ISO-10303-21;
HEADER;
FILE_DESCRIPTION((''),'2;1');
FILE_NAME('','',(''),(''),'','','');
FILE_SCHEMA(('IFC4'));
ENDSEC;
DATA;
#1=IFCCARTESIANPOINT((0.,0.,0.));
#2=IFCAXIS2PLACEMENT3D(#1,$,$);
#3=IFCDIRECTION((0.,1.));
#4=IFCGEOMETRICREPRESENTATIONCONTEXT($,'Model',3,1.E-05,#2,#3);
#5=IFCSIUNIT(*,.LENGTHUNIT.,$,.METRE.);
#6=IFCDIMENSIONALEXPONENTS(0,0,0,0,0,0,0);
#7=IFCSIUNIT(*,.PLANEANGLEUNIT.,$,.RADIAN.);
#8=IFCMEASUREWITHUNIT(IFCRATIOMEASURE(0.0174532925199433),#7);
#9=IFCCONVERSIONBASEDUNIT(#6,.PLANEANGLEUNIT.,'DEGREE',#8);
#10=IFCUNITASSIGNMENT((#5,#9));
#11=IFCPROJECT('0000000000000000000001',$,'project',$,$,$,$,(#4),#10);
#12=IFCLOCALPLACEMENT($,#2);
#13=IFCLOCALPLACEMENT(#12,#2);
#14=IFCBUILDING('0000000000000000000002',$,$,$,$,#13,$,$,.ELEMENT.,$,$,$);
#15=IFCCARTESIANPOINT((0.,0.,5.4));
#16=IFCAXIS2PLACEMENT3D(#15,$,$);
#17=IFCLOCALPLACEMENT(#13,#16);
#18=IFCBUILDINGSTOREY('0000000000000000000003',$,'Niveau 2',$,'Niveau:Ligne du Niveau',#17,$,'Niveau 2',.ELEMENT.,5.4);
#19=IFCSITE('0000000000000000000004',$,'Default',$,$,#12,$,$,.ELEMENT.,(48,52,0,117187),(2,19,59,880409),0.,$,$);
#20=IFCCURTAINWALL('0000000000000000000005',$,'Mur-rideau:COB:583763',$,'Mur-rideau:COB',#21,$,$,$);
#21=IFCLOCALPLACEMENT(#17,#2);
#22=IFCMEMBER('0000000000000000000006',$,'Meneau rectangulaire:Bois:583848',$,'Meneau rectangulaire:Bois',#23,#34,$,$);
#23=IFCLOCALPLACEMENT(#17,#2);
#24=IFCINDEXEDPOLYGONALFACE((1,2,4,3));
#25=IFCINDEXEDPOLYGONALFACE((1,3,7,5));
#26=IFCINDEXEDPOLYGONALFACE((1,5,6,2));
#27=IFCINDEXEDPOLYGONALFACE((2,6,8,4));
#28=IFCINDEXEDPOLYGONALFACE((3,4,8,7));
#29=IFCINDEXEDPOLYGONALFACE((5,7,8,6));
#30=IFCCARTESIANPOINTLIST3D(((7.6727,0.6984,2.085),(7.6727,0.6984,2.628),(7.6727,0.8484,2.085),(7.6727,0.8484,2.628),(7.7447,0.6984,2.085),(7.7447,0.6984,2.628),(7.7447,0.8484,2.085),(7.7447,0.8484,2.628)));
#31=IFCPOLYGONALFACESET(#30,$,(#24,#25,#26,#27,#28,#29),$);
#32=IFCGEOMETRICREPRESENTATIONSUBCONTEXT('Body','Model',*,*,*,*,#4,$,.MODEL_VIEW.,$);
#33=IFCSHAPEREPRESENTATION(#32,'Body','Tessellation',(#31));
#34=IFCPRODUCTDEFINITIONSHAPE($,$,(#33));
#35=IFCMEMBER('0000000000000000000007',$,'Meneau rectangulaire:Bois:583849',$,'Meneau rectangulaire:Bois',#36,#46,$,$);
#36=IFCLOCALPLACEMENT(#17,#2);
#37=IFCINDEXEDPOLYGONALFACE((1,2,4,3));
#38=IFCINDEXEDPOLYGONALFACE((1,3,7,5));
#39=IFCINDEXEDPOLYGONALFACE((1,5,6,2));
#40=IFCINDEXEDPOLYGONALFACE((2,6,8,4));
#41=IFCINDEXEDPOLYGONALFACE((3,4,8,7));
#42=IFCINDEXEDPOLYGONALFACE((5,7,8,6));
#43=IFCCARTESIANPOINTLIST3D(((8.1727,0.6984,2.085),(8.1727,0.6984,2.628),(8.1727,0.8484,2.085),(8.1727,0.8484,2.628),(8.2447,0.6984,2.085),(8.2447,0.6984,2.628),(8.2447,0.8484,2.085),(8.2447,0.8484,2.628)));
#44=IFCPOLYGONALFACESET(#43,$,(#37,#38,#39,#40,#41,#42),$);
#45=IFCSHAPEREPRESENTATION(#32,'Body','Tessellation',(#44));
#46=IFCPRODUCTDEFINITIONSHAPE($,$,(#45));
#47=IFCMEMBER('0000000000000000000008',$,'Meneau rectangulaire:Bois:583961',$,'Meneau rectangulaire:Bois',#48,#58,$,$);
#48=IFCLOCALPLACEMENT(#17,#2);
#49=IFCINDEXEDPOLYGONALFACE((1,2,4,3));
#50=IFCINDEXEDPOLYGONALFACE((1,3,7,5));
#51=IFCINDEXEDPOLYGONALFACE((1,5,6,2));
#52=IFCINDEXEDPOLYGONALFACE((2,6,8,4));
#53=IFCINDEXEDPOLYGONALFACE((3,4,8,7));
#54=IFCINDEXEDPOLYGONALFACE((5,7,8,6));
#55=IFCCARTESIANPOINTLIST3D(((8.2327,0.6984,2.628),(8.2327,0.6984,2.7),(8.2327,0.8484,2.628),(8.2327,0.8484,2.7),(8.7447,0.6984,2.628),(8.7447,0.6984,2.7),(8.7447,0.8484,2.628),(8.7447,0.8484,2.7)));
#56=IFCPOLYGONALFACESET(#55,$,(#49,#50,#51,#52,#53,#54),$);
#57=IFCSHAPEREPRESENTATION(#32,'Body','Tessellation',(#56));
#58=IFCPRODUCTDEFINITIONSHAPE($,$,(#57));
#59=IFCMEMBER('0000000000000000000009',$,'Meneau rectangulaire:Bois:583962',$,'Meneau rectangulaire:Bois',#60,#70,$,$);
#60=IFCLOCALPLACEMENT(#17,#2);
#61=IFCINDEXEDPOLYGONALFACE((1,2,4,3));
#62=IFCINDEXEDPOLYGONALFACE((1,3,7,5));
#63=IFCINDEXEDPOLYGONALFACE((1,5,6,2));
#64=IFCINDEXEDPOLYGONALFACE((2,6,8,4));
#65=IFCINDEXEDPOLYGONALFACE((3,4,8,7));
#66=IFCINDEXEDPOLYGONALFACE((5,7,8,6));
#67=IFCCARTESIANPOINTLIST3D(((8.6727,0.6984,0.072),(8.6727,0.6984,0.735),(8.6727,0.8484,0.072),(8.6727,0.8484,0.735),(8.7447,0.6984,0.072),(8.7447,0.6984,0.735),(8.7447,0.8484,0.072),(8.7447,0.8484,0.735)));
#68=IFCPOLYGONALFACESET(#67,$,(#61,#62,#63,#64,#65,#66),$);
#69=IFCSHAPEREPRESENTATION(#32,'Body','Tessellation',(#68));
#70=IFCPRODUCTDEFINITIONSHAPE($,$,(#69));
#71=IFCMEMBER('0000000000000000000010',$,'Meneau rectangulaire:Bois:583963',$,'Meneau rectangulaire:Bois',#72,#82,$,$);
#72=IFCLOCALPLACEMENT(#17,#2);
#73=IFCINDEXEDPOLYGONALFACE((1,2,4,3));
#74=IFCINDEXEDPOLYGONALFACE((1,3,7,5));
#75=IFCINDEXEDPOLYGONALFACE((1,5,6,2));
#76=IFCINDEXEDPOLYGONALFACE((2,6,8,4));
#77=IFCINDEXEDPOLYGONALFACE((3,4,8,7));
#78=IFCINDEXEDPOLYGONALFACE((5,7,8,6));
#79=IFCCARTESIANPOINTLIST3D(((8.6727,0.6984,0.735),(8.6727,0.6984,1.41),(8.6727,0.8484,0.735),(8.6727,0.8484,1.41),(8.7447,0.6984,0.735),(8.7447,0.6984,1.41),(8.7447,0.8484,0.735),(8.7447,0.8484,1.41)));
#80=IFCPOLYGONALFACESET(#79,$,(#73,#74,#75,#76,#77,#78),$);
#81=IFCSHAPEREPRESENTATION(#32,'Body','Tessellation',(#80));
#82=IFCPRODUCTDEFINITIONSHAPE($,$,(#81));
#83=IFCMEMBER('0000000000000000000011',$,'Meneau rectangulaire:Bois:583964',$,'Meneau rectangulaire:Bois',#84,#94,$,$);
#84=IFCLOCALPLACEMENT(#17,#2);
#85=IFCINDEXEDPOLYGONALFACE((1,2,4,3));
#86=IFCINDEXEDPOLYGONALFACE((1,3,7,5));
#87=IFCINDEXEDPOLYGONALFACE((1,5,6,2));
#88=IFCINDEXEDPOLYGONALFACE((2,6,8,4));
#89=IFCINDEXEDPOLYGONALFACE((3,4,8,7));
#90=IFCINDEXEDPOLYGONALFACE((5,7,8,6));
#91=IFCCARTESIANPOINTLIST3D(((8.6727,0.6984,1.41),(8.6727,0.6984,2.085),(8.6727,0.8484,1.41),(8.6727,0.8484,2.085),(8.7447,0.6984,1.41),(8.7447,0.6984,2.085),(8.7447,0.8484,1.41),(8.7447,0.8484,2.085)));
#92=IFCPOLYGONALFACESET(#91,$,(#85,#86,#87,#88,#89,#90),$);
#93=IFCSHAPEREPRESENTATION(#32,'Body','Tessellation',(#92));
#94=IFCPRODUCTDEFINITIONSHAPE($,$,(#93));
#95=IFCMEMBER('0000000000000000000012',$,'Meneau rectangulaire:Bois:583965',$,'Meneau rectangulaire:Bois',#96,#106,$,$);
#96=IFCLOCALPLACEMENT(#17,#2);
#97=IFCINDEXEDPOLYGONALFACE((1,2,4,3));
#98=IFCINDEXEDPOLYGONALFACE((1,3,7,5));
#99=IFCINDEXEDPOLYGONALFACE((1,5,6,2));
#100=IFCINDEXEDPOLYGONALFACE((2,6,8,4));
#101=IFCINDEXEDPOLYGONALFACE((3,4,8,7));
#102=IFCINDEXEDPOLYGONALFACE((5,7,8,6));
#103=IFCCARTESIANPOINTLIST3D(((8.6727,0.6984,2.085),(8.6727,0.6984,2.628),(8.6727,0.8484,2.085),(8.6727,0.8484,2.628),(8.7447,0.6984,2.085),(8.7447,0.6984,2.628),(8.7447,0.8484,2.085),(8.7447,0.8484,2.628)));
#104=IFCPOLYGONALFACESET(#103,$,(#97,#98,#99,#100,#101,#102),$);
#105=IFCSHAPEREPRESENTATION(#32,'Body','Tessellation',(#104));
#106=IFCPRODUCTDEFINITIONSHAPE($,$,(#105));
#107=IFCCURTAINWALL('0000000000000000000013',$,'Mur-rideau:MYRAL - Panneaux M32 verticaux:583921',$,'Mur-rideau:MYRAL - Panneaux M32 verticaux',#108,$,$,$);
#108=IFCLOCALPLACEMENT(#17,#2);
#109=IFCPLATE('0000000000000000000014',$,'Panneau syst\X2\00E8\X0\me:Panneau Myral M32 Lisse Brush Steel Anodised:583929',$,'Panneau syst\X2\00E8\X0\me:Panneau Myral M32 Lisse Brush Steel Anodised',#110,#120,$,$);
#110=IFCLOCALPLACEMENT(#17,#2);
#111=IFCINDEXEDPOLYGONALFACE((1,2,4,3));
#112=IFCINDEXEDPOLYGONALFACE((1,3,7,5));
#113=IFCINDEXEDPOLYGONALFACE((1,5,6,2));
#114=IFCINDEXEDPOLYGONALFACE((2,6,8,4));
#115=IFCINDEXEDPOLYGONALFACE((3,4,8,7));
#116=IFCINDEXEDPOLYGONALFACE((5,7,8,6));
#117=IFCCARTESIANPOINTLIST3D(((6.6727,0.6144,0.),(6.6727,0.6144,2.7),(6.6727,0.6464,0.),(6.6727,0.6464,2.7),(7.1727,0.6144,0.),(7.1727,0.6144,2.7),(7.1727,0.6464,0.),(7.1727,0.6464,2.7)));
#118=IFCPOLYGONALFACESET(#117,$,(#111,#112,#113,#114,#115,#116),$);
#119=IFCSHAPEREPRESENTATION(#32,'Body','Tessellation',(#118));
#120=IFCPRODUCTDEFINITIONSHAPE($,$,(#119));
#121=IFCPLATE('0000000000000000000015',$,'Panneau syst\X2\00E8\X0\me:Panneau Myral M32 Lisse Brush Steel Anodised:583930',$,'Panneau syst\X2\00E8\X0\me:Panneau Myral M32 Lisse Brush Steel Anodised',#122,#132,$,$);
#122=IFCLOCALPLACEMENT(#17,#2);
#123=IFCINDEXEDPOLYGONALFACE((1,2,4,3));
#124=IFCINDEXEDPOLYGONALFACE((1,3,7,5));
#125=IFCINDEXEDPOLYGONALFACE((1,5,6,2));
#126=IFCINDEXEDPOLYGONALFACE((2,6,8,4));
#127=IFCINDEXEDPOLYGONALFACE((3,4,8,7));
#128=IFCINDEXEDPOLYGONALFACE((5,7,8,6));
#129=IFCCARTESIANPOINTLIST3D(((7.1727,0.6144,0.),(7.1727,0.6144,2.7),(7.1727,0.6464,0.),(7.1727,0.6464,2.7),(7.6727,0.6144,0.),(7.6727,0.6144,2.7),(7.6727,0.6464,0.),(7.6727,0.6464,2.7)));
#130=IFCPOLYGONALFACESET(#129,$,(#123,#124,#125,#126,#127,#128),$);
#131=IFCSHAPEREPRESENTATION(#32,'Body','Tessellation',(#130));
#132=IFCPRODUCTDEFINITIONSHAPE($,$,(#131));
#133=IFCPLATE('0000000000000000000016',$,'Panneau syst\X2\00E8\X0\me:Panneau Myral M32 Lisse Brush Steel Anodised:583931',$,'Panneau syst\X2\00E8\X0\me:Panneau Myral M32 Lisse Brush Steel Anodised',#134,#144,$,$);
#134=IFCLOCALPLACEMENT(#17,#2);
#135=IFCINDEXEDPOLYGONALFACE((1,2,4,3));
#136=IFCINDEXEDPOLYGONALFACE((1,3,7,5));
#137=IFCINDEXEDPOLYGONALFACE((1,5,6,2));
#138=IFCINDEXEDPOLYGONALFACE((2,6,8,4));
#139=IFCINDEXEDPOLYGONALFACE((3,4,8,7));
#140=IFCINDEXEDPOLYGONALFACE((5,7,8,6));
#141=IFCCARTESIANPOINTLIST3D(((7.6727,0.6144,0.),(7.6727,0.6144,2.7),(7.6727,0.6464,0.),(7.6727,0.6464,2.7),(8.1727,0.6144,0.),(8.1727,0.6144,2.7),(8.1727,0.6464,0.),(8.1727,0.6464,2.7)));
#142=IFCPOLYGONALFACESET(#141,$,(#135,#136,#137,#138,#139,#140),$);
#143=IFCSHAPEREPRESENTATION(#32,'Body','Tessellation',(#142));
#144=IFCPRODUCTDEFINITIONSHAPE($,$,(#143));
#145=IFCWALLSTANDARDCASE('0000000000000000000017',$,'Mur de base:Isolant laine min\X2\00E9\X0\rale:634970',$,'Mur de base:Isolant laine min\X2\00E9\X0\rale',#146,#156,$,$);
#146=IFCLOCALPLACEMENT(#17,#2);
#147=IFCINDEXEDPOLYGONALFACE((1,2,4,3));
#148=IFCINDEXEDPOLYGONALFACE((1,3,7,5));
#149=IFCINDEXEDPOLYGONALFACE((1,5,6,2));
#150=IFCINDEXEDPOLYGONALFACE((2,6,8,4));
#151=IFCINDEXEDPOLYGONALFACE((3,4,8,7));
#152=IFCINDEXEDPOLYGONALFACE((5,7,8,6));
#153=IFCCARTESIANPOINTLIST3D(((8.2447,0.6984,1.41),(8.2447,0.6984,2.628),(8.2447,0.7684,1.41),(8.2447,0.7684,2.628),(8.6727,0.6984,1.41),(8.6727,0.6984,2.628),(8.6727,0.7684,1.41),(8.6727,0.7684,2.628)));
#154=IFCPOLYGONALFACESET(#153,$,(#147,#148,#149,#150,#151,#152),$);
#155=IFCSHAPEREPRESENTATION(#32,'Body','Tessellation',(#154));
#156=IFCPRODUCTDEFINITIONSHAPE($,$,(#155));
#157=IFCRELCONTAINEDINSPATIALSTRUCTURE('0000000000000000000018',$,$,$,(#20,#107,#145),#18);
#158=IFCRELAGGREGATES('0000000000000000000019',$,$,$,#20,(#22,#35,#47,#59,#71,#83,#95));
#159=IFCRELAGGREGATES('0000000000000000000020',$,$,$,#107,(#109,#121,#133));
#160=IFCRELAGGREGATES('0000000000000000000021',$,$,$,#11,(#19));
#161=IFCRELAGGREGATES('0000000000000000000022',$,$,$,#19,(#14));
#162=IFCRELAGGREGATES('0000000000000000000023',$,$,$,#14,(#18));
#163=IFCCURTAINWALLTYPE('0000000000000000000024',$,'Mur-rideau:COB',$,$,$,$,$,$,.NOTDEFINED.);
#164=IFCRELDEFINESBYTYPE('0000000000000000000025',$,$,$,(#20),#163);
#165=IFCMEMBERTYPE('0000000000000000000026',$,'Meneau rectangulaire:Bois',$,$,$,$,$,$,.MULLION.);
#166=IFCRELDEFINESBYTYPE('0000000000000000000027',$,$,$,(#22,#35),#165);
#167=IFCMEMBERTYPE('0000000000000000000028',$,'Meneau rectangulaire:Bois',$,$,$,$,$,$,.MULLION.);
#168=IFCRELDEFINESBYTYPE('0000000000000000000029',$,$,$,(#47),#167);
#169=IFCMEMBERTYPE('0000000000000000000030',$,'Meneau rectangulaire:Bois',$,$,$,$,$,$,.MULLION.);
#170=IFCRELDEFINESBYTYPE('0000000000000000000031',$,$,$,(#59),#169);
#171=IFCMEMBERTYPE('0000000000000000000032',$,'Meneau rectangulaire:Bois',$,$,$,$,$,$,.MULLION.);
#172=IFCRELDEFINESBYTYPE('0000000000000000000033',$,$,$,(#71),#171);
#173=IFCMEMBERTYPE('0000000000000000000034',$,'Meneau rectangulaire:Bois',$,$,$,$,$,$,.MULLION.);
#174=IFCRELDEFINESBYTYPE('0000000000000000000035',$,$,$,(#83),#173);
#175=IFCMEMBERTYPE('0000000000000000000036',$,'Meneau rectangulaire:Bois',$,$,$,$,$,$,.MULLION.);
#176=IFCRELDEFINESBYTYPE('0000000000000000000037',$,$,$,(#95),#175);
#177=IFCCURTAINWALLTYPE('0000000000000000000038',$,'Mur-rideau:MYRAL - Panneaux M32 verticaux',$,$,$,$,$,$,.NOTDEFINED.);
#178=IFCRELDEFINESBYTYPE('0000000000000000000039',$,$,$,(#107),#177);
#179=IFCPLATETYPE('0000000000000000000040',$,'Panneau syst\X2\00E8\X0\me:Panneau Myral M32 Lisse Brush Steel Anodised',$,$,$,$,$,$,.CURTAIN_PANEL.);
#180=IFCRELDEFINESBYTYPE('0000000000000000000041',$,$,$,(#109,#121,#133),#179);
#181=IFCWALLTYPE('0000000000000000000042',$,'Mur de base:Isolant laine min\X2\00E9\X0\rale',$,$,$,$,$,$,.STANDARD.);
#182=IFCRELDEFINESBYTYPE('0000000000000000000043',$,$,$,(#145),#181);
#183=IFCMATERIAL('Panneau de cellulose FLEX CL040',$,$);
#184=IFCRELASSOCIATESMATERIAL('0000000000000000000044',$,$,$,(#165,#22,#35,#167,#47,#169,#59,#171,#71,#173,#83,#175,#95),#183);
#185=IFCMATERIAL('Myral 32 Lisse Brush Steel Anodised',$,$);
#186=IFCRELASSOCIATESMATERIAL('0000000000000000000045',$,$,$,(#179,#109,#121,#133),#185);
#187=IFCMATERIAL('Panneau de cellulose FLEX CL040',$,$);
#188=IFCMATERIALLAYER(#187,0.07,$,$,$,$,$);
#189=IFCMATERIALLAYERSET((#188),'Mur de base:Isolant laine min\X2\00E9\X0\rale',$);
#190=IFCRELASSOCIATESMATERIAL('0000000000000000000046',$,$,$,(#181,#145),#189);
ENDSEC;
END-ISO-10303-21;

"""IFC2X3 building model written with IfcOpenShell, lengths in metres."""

from ifc_helpers import new_model, entity, si_unit, converted_unit, direction, frame, frame_2d, origin, origin_2d_with_axis, place, context, subcontext, project, spatial, rectangle, extrude, source, transform, mapped, material, layer, layer_set, layer_usage, type_object, type_shapes, element, aggregate, save


model = new_model("IFC2X3")

# Units and contexts
model_context = context("Model", 3, precision=1e-05, world=origin(), true_north=direction((0.0, 1.0)))
body_context = subcontext(model_context, "Body", "Model", "MODEL_VIEW")
ifc_project = project(units=[si_unit("LENGTHUNIT", "METRE"), converted_unit("PLANEANGLEUNIT", "DEGREE", entity("IfcRatioMeasure", 0.0174532925199433), si_unit("PLANEANGLEUNIT", "RADIAN"), dimensions=[0, 0, 0, 0, 0, 0, 0])], contexts=[model_context])

# Site, building, storey
site_placement = place(None, origin())
site = spatial("IfcSite", under=ifc_project, at=site_placement, Name="Default", CompositionType="ELEMENT", RefLatitude=(48, 52, 0, 117187), RefLongitude=(2, 19, 59, 880409), RefElevation=0.0)
building_placement = place(site_placement, origin())
building = spatial("IfcBuilding", under=site, at=building_placement, CompositionType="ELEMENT")
storey_placement = place(building_placement, frame((0.0, 0.0, 5.4)))
storey = spatial("IfcBuildingStorey", under=building, at=storey_placement, Name="Niveau 2", ObjectType="Niveau:Ligne du Niveau", LongName="Niveau 2", CompositionType="ELEMENT", Elevation=5.4)

# Curtain wall, members
curtain_wall_type_1 = type_object("IfcCurtainWallType", Name="Mur-rideau:COB", PredefinedType="NOTDEFINED")
curtain_wall_1_placement = place(storey_placement, frame((0.0, 0.0, -5.4)))
curtain_wall_1 = element("IfcCurtainWall", 1, at=curtain_wall_1_placement, inside=storey, type_object=curtain_wall_type_1, Name="Mur-rideau:COB:583763", ObjectType="Mur-rideau:COB")
ifc_material_1 = material(Name="Panneau de cellulose FLEX CL040")
member_type_1 = type_object("IfcMemberType", Name="Meneau rectangulaire:Bois", PredefinedType="MULLION", material=ifc_material_1)
shared_shape_1 = source(origin(), body_context, "Body", "SweptSolid", [
    extrude(rectangle(XDim=0.15, YDim=0.072, at=origin_2d_with_axis()), frame((-0.024, 0.0, -0.543), z_axis=(0.0, 0.0, 1.0), x_axis=(0.0, -1.0, 0.0)), (0.0, 0.0, 1.0), 0.543),
])
type_shapes(member_type_1, [shared_shape_1])
member_1_placement = place(storey_placement, frame((7.7327, 0.7734, 2.085), z_axis=(0.0, 0.0, -1.0), x_axis=(1.0, 0.0, 0.0)))
member_1 = element("IfcMember", 2, at=member_1_placement, type_object=member_type_1, material=ifc_material_1, Name="Meneau rectangulaire:Bois:583848", ObjectType="Meneau rectangulaire:Bois", context=body_context, shape_type="MappedRepresentation", body=[
    mapped(shared_shape_1, transform((0.0, 0.0, 0.0), scale=1.0)),
])
member_2_placement = place(storey_placement, frame((8.2327, 0.7734, 2.085), z_axis=(0.0, 0.0, -1.0), x_axis=(1.0, 0.0, 0.0)))
member_2 = element("IfcMember", 3, at=member_2_placement, type_object=member_type_1, material=ifc_material_1, Name="Meneau rectangulaire:Bois:583849", ObjectType="Meneau rectangulaire:Bois", context=body_context, shape_type="MappedRepresentation", body=[
    mapped(shared_shape_1, transform((0.0, 0.0, 0.0), scale=1.0)),
])
member_type_2 = type_object("IfcMemberType", Name="Meneau rectangulaire:Bois", PredefinedType="MULLION", material=ifc_material_1)
shared_shape_2 = source(origin(), body_context, "Body", "SweptSolid", [
    extrude(rectangle(XDim=0.15, YDim=0.072, at=origin_2d_with_axis()), frame((-0.036, 0.0, -0.512), z_axis=(0.0, 0.0, 1.0), x_axis=(0.0, -1.0, 0.0)), (0.0, 0.0, 1.0), 0.512),
])
type_shapes(member_type_2, [shared_shape_2])
member_3_placement = place(storey_placement, frame((8.7447, 0.7734, 2.7), z_axis=(1.0, 0.0, 0.0), x_axis=(0.0, 0.0, 1.0)))
member_3 = element("IfcMember", 4, at=member_3_placement, type_object=member_type_2, material=ifc_material_1, Name="Meneau rectangulaire:Bois:583961", ObjectType="Meneau rectangulaire:Bois", context=body_context, shape_type="MappedRepresentation", body=[
    mapped(shared_shape_2, transform((0.0, 0.0, 0.0), scale=1.0)),
])
member_type_3 = type_object("IfcMemberType", Name="Meneau rectangulaire:Bois", PredefinedType="MULLION", material=ifc_material_1)
shared_shape_3 = source(origin(), body_context, "Body", "SweptSolid", [
    extrude(rectangle(XDim=0.15, YDim=0.072, at=origin_2d_with_axis()), frame((-0.024, 0.0, -0.663), z_axis=(0.0, 0.0, 1.0), x_axis=(0.0, -1.0, 0.0)), (0.0, 0.0, 1.0), 0.663),
])
type_shapes(member_type_3, [shared_shape_3])
member_4_placement = place(storey_placement, frame((8.7327, 0.7734, 0.072), z_axis=(0.0, 0.0, -1.0), x_axis=(1.0, 0.0, 0.0)))
member_4 = element("IfcMember", 5, at=member_4_placement, type_object=member_type_3, material=ifc_material_1, Name="Meneau rectangulaire:Bois:583962", ObjectType="Meneau rectangulaire:Bois", context=body_context, shape_type="MappedRepresentation", body=[
    mapped(shared_shape_3, transform((0.0, 0.0, 0.0), scale=1.0)),
])
member_type_4 = type_object("IfcMemberType", Name="Meneau rectangulaire:Bois", PredefinedType="MULLION", material=ifc_material_1)
shared_shape_4 = source(origin(), body_context, "Body", "SweptSolid", [
    extrude(rectangle(XDim=0.15, YDim=0.072, at=origin_2d_with_axis()), frame((-0.024, 0.0, -0.675), z_axis=(0.0, 0.0, 1.0), x_axis=(0.0, -1.0, 0.0)), (0.0, 0.0, 1.0), 0.675),
])
type_shapes(member_type_4, [shared_shape_4])
member_5_placement = place(storey_placement, frame((8.7327, 0.7734, 0.735), z_axis=(0.0, 0.0, -1.0), x_axis=(1.0, 0.0, 0.0)))
member_5 = element("IfcMember", 6, at=member_5_placement, type_object=member_type_4, material=ifc_material_1, Name="Meneau rectangulaire:Bois:583963", ObjectType="Meneau rectangulaire:Bois", context=body_context, shape_type="MappedRepresentation", body=[
    mapped(shared_shape_4, transform((0.0, 0.0, 0.0), scale=1.0)),
])
member_type_5 = type_object("IfcMemberType", Name="Meneau rectangulaire:Bois", PredefinedType="MULLION", material=ifc_material_1)
shared_shape_5 = source(origin(), body_context, "Body", "SweptSolid", [
    extrude(rectangle(XDim=0.15, YDim=0.072, at=origin_2d_with_axis()), frame((-0.024, 0.0, -0.675), z_axis=(0.0, 0.0, 1.0), x_axis=(0.0, -1.0, 0.0)), (0.0, 0.0, 1.0), 0.675),
])
type_shapes(member_type_5, [shared_shape_5])
member_6_placement = place(storey_placement, frame((8.7327, 0.7734, 1.41), z_axis=(0.0, 0.0, -1.0), x_axis=(1.0, 0.0, 0.0)))
member_6 = element("IfcMember", 7, at=member_6_placement, type_object=member_type_5, material=ifc_material_1, Name="Meneau rectangulaire:Bois:583964", ObjectType="Meneau rectangulaire:Bois", context=body_context, shape_type="MappedRepresentation", body=[
    mapped(shared_shape_5, transform((0.0, 0.0, 0.0), scale=1.0)),
])
member_type_6 = type_object("IfcMemberType", Name="Meneau rectangulaire:Bois", PredefinedType="MULLION", material=ifc_material_1)
shared_shape_6 = source(origin(), body_context, "Body", "SweptSolid", [
    extrude(rectangle(XDim=0.15, YDim=0.072, at=origin_2d_with_axis()), frame((-0.024, 0.0, -0.543), z_axis=(0.0, 0.0, 1.0), x_axis=(0.0, -1.0, 0.0)), (0.0, 0.0, 1.0), 0.543),
])
type_shapes(member_type_6, [shared_shape_6])
member_7_placement = place(storey_placement, frame((8.7327, 0.7734, 2.085), z_axis=(0.0, 0.0, -1.0), x_axis=(1.0, 0.0, 0.0)))
member_7 = element("IfcMember", 8, at=member_7_placement, type_object=member_type_6, material=ifc_material_1, Name="Meneau rectangulaire:Bois:583965", ObjectType="Meneau rectangulaire:Bois", context=body_context, shape_type="MappedRepresentation", body=[
    mapped(shared_shape_6, transform((0.0, 0.0, 0.0), scale=1.0)),
])
aggregate(curtain_wall_1, [member_1, member_2, member_3, member_4, member_5, member_6, member_7])

# Curtain wall, plates
curtain_wall_type_2 = type_object("IfcCurtainWallType", Name="Mur-rideau:MYRAL - Panneaux M32 verticaux", PredefinedType="NOTDEFINED")
curtain_wall_2_placement = place(storey_placement, frame((0.0, 0.0, -5.4)))
curtain_wall_2 = element("IfcCurtainWall", 9, at=curtain_wall_2_placement, inside=storey, type_object=curtain_wall_type_2, Name="Mur-rideau:MYRAL - Panneaux M32 verticaux:583921", ObjectType="Mur-rideau:MYRAL - Panneaux M32 verticaux")
ifc_material_2 = material(Name="Myral 32 Lisse Brush Steel Anodised")
plate_type = type_object("IfcPlateType", Name="Panneau système:Panneau Myral M32 Lisse Brush Steel Anodised", PredefinedType="CURTAIN_PANEL", material=ifc_material_2)
shared_shape_7 = source(origin(), body_context, "Body", "SweptSolid", [
    extrude(rectangle(XDim=0.032, YDim=0.5, at=origin_2d_with_axis()), frame((0.0, -0.016, 0.0), z_axis=(0.0, 0.0, 1.0), x_axis=(0.0, 1.0, 0.0)), (0.0, 0.0, 1.0), 2.7),
])
type_shapes(plate_type, [shared_shape_7])
plate_1_placement = place(curtain_wall_2_placement, frame((6.9227, 0.6464, 5.4)))
plate_1 = element("IfcPlate", 10, at=plate_1_placement, type_object=plate_type, material=ifc_material_2, Name="Panneau système:Panneau Myral M32 Lisse Brush Steel Anodised:583929", ObjectType="Panneau système:Panneau Myral M32 Lisse Brush Steel Anodised", context=body_context, shape_type="MappedRepresentation", body=[
    mapped(shared_shape_7, transform((0.0, 0.0, 0.0), scale=1.0)),
])
plate_2_placement = place(curtain_wall_2_placement, frame((7.4227, 0.6464, 5.4)))
plate_2 = element("IfcPlate", 11, at=plate_2_placement, type_object=plate_type, material=ifc_material_2, Name="Panneau système:Panneau Myral M32 Lisse Brush Steel Anodised:583930", ObjectType="Panneau système:Panneau Myral M32 Lisse Brush Steel Anodised", context=body_context, shape_type="MappedRepresentation", body=[
    mapped(shared_shape_7, transform((0.0, 0.0, 0.0), scale=1.0)),
])
plate_3_placement = place(curtain_wall_2_placement, frame((7.9227, 0.6464, 5.4)))
plate_3 = element("IfcPlate", 12, at=plate_3_placement, type_object=plate_type, material=ifc_material_2, Name="Panneau système:Panneau Myral M32 Lisse Brush Steel Anodised:583931", ObjectType="Panneau système:Panneau Myral M32 Lisse Brush Steel Anodised", context=body_context, shape_type="MappedRepresentation", body=[
    mapped(shared_shape_7, transform((0.0, 0.0, 0.0), scale=1.0)),
])
aggregate(curtain_wall_2, [plate_1, plate_2, plate_3])

# Wall
ifc_material_3 = material(Name="Panneau de cellulose FLEX CL040")
ifc_layer = layer(ifc_material_3, 0.07)
ifc_layer_set = layer_set([ifc_layer], Name="Mur de base:Isolant laine minérale")
ifc_layer_usage = layer_usage(ifc_layer_set, "AXIS2", "NEGATIVE", 0.035)
wall_type = type_object("IfcWallType", Name="Mur de base:Isolant laine minérale", PredefinedType="STANDARD", material=ifc_layer_set)
wall_placement = place(storey_placement, frame((8.2447, 0.7334, 1.41)))
element("IfcWallStandardCase", 13, at=wall_placement, inside=storey, type_object=wall_type, material=ifc_layer_usage, Name="Mur de base:Isolant laine minérale:634970", ObjectType="Mur de base:Isolant laine minérale", context=body_context, shape_type="SweptSolid", body=[
    extrude(rectangle(XDim=0.428, YDim=0.07, at=frame_2d((0.214, 0.0), x_axis=(-1.0, 0.0))), origin(), (0.0, 0.0, 1.0), 1.218),
])

save(model, "model.ifc")
